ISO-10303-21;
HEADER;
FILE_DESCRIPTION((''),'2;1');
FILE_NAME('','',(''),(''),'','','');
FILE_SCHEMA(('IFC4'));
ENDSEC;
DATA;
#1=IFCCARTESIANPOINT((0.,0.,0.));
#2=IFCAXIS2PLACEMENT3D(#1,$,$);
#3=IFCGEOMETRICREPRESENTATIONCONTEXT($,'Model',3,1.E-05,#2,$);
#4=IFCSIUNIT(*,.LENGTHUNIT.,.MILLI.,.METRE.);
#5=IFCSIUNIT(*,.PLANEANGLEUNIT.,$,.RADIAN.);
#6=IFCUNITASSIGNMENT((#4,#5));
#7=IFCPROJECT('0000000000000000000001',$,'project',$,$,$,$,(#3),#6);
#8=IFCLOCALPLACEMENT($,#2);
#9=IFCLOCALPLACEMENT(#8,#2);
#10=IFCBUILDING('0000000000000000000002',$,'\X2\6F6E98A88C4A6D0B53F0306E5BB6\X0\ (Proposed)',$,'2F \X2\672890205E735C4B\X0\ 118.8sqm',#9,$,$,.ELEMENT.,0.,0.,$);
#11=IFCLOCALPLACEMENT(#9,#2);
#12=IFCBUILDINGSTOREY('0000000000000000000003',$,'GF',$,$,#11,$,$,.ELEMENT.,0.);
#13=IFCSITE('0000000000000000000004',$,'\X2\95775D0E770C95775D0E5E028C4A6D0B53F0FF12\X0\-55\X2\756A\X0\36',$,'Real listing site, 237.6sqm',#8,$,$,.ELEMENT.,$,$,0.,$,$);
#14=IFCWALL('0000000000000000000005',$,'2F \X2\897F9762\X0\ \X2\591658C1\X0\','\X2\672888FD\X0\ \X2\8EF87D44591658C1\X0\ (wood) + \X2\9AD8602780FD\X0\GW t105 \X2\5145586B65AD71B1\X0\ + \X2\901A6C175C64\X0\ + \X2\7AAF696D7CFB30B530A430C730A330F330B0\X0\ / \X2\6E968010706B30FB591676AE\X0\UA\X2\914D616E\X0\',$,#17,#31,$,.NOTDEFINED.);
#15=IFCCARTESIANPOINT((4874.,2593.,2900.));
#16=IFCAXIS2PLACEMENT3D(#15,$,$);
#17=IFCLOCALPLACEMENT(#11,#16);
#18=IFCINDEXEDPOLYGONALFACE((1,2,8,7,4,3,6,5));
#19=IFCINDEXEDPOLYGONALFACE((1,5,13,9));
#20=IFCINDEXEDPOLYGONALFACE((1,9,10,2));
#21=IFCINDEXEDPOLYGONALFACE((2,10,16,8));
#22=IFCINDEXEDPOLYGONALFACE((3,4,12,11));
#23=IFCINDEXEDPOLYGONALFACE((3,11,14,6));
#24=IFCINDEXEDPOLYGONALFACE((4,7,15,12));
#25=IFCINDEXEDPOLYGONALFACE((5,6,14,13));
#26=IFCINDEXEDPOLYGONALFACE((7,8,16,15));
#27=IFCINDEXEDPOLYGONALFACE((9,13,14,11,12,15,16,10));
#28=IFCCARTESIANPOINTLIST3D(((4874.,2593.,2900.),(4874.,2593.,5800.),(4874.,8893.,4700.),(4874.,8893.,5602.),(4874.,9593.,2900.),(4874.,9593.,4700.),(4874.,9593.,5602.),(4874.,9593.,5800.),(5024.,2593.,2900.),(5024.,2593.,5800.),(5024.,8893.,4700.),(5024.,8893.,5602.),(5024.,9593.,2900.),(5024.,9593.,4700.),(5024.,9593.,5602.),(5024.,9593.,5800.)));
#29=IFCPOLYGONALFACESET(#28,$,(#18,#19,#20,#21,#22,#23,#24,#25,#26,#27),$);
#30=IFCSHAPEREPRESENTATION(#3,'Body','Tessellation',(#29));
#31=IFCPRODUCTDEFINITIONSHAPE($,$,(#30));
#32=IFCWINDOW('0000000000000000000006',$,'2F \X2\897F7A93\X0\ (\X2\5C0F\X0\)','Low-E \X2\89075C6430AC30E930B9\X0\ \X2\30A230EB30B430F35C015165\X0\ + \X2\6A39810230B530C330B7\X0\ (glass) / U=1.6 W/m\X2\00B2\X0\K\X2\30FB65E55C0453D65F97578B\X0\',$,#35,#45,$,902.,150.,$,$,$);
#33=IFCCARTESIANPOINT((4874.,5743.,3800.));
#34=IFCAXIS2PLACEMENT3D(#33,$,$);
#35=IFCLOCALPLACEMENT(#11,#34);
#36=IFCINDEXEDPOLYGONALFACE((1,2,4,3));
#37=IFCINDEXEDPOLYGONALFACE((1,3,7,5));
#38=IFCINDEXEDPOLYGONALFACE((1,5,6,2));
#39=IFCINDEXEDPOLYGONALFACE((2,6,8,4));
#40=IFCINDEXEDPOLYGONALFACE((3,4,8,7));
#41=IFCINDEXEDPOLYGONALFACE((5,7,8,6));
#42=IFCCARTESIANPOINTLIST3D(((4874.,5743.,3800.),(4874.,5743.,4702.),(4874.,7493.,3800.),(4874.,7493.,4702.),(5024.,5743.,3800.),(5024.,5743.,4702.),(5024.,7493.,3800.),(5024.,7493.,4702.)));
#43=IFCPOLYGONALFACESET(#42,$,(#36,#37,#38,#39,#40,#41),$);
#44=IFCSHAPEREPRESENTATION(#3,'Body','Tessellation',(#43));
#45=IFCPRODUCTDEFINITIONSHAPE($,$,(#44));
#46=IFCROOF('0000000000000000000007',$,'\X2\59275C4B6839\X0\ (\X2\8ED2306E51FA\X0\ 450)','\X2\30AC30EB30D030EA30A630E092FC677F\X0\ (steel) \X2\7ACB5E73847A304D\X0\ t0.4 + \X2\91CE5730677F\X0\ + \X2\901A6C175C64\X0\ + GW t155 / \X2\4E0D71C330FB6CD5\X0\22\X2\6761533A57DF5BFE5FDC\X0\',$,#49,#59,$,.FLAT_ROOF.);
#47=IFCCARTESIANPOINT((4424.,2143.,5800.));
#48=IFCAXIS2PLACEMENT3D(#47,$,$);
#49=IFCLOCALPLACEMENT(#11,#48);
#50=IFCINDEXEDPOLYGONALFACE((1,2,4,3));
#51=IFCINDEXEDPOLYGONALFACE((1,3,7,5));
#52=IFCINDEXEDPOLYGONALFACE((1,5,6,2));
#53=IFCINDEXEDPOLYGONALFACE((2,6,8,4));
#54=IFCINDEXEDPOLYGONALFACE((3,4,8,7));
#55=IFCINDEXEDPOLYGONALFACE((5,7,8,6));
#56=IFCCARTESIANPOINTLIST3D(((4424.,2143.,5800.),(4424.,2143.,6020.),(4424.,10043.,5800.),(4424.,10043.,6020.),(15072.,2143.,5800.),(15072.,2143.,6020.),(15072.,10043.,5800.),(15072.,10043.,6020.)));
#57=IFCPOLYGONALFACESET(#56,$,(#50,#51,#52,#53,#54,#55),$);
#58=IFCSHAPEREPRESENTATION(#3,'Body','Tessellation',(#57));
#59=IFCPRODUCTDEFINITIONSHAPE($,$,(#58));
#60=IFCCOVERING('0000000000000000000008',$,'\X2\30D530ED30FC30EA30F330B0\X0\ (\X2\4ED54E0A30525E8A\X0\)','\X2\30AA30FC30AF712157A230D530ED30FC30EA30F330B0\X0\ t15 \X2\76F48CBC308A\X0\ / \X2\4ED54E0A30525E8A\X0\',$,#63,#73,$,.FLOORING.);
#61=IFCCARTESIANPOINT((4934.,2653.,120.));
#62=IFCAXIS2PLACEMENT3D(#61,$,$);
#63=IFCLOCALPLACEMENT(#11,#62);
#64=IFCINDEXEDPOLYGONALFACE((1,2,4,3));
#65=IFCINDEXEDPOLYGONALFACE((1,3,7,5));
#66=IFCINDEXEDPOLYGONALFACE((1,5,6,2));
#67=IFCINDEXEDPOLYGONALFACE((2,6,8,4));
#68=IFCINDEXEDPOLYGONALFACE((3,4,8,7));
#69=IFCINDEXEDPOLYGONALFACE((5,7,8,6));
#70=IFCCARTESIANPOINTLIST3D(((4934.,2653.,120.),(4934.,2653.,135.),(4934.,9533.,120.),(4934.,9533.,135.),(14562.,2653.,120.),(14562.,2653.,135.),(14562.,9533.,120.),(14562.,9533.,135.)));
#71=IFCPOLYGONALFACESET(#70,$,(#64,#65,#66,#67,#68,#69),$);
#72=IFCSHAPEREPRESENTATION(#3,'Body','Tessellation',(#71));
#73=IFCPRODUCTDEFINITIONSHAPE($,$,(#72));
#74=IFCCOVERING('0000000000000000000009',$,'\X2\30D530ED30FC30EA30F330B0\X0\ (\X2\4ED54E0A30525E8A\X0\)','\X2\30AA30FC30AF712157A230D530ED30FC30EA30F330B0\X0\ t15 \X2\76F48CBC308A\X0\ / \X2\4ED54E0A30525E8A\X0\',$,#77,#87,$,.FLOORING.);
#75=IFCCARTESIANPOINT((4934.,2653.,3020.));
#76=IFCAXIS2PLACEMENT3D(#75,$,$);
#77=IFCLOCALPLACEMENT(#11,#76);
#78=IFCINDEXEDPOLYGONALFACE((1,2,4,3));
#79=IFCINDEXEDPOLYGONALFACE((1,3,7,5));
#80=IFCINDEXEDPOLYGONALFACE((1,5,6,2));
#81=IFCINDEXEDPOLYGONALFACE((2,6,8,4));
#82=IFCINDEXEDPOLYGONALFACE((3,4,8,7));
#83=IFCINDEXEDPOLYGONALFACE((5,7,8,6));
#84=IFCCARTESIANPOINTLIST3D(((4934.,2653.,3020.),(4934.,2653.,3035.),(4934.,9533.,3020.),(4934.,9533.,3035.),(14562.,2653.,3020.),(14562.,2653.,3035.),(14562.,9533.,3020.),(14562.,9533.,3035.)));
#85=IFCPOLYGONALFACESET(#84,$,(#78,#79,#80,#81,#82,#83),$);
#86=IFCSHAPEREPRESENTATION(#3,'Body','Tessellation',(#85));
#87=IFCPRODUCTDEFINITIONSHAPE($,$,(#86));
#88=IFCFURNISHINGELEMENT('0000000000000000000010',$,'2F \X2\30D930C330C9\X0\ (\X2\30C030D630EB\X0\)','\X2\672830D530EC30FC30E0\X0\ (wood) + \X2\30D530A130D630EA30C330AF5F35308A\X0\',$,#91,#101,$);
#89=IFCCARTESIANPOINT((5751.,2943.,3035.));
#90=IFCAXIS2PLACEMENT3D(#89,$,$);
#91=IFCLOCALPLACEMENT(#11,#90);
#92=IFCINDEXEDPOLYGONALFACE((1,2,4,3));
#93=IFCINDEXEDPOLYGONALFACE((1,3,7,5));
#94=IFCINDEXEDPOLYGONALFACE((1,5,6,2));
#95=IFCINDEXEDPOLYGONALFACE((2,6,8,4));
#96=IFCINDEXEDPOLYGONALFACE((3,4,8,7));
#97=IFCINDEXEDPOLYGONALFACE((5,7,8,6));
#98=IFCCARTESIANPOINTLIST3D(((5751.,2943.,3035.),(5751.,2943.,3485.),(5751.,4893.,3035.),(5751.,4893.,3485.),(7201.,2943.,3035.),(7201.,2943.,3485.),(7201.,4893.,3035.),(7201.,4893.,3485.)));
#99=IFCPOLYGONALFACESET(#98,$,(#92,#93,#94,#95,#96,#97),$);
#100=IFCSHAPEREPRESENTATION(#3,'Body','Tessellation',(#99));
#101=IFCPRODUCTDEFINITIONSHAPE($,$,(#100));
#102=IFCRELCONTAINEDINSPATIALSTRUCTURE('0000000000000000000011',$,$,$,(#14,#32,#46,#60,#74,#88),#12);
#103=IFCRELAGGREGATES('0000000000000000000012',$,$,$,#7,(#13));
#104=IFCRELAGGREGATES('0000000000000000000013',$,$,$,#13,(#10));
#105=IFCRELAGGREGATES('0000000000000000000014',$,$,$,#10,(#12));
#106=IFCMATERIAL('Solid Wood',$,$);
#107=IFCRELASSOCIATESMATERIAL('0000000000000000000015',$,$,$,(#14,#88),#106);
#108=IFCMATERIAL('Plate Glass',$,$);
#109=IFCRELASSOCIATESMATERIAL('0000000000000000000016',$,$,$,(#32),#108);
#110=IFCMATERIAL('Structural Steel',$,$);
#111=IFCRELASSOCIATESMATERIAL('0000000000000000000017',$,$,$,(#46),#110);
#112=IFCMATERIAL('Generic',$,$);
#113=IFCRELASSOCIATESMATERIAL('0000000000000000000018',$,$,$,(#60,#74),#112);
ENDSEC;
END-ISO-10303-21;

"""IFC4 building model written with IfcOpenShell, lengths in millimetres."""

from ifc_helpers import new_model, si_unit, frame, frame_2d, origin, place, context, project, spatial, rectangle, extrude, material, element, fill, save


model = new_model("IFC4")

# Units and contexts
model_context = context("Model", 3, precision=1e-05, world=origin())
ifc_project = project(units=[si_unit("LENGTHUNIT", "METRE", prefix="MILLI"), si_unit("PLANEANGLEUNIT", "RADIAN")], contexts=[model_context])

# Site, building, storey
site_placement = place(None, origin())
site = spatial("IfcSite", under=ifc_project, at=site_placement, Name="長崎県長崎市豊洋台２-55番36", ObjectType="Real listing site, 237.6sqm", CompositionType="ELEMENT", RefElevation=0.0)
building_placement = place(site_placement, origin())
building = spatial("IfcBuilding", under=site, at=building_placement, Name="潮風豊洋台の家 (Proposed)", ObjectType="2F 木造平屋 118.8sqm", CompositionType="ELEMENT", ElevationOfRefHeight=0.0, ElevationOfTerrain=0.0)
storey_placement = place(building_placement, origin())
storey = spatial("IfcBuildingStorey", under=building, at=storey_placement, Name="GF", CompositionType="ELEMENT", Elevation=0.0)

# Shared definitions
ifc_material_1 = material(Name="Solid Wood")

# Shared definitions
ifc_material_2 = material(Name="Plate Glass")

# Wall, opening, window
wall_1_placement = place(storey_placement, frame((4874.0, 2593.0, 2900.0)))
wall_1 = element("IfcWall", 1, at=wall_1_placement, inside=storey, material=ifc_material_1, Name="2F 西面 外壁", Description="木製 軸組外壁 (wood) + 高性能GW t105 充填断熱 + 通気層 + 窯業系サイディング / 準耐火・外皮UA配慮", PredefinedType="NOTDEFINED", context=model_context, shape_type="SweptSolid", body=[
    extrude(rectangle(XDim=150.0, YDim=7000.0, at=frame_2d((75.0, 3500.0))), frame((4874.0, 2593.0, 2900.0)), (0.0, 0.0, 1.0), 2900.0),
])
opening_1_placement = place(storey_placement, frame((4874.0, 5743.0, 3800.0)))
opening_1 = element("IfcOpeningElement", 2, at=opening_1_placement, cuts=wall_1, PredefinedType="NOTDEFINED", context=model_context, shape_type="SweptSolid", body=[
    extrude(rectangle(XDim=150.0, YDim=1750.0, at=frame_2d((75.0, 875.0))), frame((4874.0, 5743.0, 3800.0)), (0.0, 0.0, 1.0), 902.0),
])
window_1_placement = place(storey_placement, frame((4874.0, 5743.0, 3800.0)))
window_1 = element("IfcWindow", 3, at=window_1_placement, inside=storey, material=ifc_material_2, Name="2F 西窓 (小)", Description="Low-E 複層ガラス アルゴン封入 + 樹脂サッシ (glass) / U=1.6 W/m²K・日射取得型", OverallHeight=902.0, OverallWidth=150.0, context=model_context, shape_type="SweptSolid", body=[
    extrude(rectangle(XDim=150.0, YDim=1750.0, at=frame_2d((75.0, 875.0))), frame((4874.0, 5743.0, 3800.0)), (0.0, 0.0, 1.0), 902.0),
])
fill(opening_1, window_1)

# Roof
ifc_material_3 = material(Name="Structural Steel")
roof_placement = place(storey_placement, frame((4424.0, 2143.0, 5800.0)))
element("IfcRoof", 4, at=roof_placement, inside=storey, material=ifc_material_3, Name="大屋根 (軒の出 450)", Description="ガルバリウム鋼板 (steel) 立平葺き t0.4 + 野地板 + 通気層 + GW t155 / 不燃・法22条区域対応", PredefinedType="FLAT_ROOF", context=model_context, shape_type="SweptSolid", body=[
    extrude(rectangle(XDim=10648.0, YDim=7900.0, at=frame_2d((5324.0, 3950.0))), frame((4424.0, 2143.0, 5800.0)), (0.0, 0.0, 1.0), 220.0),
])

# Coverings
ifc_material_4 = material(Name="Generic")
covering_1_placement = place(storey_placement, frame((4934.0, 2653.0, 120.0)))
element("IfcCovering", 5, at=covering_1_placement, inside=storey, material=ifc_material_4, Name="フローリング (仕上げ床)", Description="オーク無垢フローリング t15 直貼り / 仕上げ床", PredefinedType="FLOORING", context=model_context, shape_type="SweptSolid", body=[
    extrude(rectangle(XDim=9628.0, YDim=6880.0, at=frame_2d((4814.0, 3440.0))), frame((4934.0, 2653.0, 120.0)), (0.0, 0.0, 1.0), 15.0),
])
covering_2_placement = place(storey_placement, frame((4934.0, 2653.0, 3020.0)))
element("IfcCovering", 6, at=covering_2_placement, inside=storey, material=ifc_material_4, Name="フローリング (仕上げ床)", Description="オーク無垢フローリング t15 直貼り / 仕上げ床", PredefinedType="FLOORING", context=model_context, shape_type="SweptSolid", body=[
    extrude(rectangle(XDim=9628.0, YDim=6880.0, at=frame_2d((4814.0, 3440.0))), frame((4934.0, 2653.0, 3020.0)), (0.0, 0.0, 1.0), 15.0),
])

# Furnishing element
furnishing_placement = place(storey_placement, frame((5751.0, 2943.0, 3035.0)))
element("IfcFurnishingElement", 7, at=furnishing_placement, inside=storey, material=ifc_material_1, Name="2F ベッド (ダブル)", Description="木フレーム (wood) + ファブリック張り", context=model_context, shape_type="SweptSolid", body=[
    extrude(rectangle(XDim=1450.0, YDim=1950.0, at=frame_2d((725.0, 975.0))), frame((5751.0, 2943.0, 3035.0)), (0.0, 0.0, 1.0), 450.0),
])

save(model, "model.ifc")
